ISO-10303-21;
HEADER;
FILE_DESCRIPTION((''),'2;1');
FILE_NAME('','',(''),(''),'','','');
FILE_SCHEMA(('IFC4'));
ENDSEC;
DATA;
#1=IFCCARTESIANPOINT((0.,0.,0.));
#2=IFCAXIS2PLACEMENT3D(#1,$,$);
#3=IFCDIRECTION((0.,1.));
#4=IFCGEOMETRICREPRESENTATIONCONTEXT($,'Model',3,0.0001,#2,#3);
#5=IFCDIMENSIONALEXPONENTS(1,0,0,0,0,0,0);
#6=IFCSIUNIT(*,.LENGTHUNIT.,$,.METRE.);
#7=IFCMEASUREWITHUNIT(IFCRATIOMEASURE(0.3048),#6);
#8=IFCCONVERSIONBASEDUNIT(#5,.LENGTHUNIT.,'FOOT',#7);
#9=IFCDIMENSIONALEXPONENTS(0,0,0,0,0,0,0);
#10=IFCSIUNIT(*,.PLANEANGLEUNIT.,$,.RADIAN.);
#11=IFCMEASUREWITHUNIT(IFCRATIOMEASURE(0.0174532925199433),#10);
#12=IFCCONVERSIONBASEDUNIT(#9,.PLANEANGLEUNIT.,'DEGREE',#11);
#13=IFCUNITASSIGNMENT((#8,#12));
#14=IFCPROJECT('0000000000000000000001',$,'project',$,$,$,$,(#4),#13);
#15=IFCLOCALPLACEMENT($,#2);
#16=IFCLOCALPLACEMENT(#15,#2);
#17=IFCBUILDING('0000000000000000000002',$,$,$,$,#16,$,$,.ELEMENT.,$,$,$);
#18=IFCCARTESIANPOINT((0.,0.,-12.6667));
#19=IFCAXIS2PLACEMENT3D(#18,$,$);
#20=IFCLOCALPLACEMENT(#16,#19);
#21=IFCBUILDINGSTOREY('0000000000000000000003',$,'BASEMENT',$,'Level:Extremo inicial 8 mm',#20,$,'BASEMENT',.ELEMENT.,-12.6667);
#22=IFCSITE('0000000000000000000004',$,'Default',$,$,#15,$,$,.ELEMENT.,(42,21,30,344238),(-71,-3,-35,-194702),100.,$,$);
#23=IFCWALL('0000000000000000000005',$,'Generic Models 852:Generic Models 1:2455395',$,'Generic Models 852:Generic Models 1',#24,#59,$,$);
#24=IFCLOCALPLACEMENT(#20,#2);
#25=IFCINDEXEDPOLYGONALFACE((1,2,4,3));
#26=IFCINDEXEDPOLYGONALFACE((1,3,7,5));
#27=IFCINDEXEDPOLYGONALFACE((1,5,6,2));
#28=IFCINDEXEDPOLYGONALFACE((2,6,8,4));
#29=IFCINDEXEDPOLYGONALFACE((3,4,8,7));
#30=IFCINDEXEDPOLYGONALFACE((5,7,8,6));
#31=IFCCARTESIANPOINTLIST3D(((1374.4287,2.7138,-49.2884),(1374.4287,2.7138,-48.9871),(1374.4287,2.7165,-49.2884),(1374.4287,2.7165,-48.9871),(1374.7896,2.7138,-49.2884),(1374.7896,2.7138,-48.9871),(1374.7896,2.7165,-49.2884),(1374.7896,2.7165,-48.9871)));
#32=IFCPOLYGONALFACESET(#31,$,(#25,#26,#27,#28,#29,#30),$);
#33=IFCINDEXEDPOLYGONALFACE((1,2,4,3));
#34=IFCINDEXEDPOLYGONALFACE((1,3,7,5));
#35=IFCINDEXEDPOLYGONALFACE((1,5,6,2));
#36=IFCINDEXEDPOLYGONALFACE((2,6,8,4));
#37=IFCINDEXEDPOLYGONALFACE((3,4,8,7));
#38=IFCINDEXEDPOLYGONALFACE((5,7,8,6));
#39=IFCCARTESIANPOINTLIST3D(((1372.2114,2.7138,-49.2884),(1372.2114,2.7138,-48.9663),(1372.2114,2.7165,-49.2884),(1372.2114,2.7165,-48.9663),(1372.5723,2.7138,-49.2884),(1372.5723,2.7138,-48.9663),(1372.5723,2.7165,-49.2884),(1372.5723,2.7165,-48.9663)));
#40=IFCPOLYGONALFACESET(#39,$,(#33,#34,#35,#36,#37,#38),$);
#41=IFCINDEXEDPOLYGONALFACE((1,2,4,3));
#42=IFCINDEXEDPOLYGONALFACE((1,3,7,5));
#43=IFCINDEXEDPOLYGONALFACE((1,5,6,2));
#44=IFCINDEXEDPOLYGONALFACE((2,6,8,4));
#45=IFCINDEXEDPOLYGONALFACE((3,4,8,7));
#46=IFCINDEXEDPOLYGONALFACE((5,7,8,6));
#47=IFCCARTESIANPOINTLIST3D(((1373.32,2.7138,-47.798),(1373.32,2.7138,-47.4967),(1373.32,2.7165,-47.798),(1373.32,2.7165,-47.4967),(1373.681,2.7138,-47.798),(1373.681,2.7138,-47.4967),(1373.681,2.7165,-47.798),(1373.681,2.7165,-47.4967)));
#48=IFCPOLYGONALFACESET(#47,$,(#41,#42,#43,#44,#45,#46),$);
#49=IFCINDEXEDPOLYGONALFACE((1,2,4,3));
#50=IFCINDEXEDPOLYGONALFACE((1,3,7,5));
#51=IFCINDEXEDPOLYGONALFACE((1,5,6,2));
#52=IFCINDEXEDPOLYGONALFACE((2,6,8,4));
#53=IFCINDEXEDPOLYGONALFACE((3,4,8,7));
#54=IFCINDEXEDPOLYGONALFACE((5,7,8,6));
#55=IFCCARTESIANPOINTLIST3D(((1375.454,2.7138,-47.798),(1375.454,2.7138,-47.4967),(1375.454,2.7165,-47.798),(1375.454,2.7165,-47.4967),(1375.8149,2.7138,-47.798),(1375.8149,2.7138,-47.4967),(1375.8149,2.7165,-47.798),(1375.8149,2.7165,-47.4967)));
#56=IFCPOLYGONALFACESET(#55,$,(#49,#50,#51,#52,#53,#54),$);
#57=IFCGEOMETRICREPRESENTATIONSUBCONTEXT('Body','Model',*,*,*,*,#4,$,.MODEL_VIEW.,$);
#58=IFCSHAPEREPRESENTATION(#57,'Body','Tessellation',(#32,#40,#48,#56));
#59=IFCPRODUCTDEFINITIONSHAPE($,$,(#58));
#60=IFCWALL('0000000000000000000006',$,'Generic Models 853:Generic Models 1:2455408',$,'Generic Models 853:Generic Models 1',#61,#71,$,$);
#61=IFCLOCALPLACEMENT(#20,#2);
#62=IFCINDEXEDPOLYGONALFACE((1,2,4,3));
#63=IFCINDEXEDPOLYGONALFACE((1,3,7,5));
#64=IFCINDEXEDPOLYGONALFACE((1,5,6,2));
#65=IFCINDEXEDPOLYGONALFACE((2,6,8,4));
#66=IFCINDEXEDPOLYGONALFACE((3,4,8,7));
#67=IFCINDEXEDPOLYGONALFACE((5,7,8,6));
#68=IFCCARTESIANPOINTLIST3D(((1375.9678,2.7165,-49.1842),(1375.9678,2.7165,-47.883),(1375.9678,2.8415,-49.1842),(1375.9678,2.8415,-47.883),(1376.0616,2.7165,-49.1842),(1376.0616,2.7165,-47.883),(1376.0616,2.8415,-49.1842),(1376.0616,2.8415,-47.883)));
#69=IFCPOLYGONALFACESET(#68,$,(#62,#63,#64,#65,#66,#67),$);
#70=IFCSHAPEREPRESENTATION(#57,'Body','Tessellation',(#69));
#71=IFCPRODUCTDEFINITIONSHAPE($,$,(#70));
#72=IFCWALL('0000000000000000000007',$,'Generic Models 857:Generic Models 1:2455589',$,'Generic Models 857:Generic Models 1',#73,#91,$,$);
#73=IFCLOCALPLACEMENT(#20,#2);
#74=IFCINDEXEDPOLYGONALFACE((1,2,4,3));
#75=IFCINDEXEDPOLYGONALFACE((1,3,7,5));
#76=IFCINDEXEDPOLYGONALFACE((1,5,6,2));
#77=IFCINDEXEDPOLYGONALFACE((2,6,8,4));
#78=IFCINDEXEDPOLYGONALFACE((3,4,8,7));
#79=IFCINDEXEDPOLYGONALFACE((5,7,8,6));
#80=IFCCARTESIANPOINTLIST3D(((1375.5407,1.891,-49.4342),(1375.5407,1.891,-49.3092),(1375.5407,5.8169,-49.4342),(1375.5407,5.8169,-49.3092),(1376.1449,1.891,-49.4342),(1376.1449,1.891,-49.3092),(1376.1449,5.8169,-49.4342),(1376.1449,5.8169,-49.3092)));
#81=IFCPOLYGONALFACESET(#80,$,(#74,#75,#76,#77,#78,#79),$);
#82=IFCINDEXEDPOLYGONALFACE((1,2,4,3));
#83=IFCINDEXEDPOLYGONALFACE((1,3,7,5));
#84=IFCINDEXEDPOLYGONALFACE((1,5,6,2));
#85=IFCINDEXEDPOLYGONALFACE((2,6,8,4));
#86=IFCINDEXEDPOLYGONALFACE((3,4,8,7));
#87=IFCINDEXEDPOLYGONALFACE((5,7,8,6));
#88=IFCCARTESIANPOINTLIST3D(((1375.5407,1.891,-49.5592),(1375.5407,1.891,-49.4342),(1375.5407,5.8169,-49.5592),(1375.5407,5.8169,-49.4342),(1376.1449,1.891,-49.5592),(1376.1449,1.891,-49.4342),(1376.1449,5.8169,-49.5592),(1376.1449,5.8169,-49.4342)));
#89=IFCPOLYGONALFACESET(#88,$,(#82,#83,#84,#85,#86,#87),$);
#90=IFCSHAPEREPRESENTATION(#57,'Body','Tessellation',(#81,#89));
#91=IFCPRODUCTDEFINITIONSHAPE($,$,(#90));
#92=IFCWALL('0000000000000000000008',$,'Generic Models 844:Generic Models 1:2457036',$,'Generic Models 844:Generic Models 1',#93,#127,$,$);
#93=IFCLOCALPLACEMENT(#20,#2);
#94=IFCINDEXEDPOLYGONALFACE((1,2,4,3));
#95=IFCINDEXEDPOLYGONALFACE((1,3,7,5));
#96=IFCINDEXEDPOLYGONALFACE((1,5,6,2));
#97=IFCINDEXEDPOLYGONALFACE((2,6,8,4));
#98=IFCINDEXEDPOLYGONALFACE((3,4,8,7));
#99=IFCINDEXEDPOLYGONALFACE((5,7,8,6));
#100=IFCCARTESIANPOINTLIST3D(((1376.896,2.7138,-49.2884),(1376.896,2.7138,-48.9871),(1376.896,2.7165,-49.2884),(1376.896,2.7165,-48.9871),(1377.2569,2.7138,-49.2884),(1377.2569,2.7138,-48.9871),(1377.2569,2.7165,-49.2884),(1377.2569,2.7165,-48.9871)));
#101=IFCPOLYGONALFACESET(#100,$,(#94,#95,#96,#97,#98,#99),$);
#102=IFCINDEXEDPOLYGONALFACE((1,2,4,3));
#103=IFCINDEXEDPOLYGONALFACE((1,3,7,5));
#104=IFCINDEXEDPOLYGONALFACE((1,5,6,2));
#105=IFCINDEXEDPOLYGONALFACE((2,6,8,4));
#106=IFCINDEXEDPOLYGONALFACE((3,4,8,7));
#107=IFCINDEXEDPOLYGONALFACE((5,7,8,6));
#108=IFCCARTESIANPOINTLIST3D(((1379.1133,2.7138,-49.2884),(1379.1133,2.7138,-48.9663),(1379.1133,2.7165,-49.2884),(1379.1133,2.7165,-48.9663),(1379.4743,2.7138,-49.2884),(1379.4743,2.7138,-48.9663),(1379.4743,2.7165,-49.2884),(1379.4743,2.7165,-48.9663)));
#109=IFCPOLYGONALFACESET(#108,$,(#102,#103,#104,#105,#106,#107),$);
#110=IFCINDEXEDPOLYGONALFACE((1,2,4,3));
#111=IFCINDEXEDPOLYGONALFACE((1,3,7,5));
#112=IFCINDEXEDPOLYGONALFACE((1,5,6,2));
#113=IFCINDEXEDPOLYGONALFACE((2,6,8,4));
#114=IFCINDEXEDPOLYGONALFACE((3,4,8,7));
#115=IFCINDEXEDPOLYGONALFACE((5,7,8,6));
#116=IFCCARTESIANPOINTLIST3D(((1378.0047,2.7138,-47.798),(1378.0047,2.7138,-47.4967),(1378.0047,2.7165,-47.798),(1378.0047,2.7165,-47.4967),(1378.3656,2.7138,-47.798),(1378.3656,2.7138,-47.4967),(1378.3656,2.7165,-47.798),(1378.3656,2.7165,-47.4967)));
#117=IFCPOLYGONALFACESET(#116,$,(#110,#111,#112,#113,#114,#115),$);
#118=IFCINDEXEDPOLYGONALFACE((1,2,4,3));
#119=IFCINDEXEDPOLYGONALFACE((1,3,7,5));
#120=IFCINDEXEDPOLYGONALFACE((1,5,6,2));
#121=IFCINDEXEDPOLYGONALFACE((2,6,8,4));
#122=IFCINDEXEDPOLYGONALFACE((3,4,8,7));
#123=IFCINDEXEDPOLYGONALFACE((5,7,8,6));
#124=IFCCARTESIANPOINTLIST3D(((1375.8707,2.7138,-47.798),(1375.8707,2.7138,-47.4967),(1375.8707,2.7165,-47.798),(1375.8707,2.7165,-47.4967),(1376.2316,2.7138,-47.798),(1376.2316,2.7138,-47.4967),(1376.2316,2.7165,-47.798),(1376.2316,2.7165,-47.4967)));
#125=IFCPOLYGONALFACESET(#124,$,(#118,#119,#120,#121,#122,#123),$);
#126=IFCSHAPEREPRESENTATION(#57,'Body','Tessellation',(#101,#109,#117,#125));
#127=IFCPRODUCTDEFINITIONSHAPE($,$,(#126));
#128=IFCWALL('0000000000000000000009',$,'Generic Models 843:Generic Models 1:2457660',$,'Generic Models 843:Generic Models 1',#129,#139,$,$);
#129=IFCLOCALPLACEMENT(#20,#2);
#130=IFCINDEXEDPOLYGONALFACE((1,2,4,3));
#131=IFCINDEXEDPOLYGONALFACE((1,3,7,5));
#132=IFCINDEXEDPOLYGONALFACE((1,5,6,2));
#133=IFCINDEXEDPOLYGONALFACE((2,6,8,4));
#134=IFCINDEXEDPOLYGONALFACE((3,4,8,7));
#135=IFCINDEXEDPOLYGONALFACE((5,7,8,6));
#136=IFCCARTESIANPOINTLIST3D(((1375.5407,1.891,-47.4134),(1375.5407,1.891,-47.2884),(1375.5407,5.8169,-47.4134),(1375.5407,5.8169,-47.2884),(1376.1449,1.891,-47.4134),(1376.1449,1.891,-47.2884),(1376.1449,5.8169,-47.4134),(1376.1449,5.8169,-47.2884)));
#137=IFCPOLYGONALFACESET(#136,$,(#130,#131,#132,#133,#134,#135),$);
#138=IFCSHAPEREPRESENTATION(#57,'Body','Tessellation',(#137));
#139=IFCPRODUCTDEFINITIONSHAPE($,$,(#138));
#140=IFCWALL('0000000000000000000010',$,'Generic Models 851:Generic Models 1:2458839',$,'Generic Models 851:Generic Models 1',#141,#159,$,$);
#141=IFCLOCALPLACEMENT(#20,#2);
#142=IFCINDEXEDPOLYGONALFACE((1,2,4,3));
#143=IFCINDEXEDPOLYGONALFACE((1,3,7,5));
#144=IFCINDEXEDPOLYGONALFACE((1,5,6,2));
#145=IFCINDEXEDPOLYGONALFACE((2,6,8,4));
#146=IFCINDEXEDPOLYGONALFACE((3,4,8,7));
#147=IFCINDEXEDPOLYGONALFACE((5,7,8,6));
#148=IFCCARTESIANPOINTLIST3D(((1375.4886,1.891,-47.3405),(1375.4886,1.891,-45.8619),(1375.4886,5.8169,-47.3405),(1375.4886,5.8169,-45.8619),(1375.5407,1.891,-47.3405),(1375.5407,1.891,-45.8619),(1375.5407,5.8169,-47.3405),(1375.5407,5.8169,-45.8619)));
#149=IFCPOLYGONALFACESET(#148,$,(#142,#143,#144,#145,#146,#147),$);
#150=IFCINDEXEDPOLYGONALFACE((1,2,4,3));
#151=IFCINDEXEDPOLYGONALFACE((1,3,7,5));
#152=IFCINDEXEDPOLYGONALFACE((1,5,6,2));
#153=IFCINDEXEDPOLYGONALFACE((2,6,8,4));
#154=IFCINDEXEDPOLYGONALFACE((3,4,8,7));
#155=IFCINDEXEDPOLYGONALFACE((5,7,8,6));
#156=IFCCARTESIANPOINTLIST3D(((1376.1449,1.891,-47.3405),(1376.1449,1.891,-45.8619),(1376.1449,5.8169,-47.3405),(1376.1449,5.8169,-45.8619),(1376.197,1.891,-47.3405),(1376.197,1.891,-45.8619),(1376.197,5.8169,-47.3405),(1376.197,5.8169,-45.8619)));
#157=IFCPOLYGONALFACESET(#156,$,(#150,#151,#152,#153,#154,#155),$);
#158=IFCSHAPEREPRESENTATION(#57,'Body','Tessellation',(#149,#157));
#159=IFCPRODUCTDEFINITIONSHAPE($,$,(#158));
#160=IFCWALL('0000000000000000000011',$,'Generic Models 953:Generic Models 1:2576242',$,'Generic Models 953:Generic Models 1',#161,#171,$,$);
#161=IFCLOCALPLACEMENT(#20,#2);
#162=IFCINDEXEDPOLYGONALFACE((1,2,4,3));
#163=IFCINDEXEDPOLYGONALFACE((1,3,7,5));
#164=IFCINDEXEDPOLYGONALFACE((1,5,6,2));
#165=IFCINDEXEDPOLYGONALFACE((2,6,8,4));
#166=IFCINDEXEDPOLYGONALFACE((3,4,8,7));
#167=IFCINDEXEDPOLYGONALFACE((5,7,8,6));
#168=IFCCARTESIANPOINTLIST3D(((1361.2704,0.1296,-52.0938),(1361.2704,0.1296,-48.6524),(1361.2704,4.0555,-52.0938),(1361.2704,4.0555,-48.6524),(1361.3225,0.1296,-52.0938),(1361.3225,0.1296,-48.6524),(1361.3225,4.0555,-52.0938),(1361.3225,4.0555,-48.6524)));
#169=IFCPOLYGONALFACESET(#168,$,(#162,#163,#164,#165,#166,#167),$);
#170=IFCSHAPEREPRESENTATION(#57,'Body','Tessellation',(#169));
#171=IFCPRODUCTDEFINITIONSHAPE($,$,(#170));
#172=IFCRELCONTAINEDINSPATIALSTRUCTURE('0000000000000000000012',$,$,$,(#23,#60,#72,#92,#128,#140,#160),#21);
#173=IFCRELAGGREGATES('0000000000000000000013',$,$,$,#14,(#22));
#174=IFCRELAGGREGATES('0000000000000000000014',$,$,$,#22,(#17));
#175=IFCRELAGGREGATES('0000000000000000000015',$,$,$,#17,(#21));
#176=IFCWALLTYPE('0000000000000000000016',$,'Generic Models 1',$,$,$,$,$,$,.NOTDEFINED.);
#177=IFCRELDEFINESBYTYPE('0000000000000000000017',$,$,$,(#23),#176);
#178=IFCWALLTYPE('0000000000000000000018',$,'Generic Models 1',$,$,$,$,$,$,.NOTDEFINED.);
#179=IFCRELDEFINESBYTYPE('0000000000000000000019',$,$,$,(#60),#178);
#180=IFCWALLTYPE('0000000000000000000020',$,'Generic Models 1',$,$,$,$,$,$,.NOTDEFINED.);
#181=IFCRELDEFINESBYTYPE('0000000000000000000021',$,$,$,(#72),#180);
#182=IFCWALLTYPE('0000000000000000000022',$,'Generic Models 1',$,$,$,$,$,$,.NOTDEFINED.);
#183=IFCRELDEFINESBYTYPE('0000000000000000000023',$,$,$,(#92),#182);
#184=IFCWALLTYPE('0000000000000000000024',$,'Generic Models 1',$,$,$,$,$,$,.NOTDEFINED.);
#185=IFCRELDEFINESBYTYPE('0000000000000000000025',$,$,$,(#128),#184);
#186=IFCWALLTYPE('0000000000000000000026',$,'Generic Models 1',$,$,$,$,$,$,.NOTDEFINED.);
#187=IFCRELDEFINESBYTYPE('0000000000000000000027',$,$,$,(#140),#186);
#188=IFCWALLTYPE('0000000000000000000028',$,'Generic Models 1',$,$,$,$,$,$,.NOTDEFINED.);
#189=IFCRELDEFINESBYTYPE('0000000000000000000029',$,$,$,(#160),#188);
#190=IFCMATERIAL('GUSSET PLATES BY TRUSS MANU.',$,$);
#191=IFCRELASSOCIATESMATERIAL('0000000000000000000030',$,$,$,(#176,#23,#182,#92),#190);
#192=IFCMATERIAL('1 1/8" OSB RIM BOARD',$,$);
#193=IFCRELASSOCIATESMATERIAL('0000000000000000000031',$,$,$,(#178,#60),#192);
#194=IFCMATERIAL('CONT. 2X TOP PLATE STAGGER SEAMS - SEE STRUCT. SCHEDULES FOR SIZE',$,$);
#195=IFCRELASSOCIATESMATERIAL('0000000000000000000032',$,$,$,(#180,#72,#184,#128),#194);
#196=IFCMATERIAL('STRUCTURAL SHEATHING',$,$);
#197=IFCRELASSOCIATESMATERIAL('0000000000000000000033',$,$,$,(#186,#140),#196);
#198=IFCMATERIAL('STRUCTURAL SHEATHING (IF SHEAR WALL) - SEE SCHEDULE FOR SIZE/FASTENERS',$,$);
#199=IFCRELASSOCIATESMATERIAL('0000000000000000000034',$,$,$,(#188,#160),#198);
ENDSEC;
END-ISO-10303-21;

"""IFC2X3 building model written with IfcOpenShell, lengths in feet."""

from ifc_helpers import new_model, entity, si_unit, converted_unit, direction, frame, frame_2d, origin, origin_2d_with_axis, place, context, subcontext, project, spatial, rectangle, extrude, material, type_object, element, save


model = new_model("IFC2X3")

# Units and contexts
model_context = context("Model", 3, precision=0.0001, world=origin(), true_north=direction((0.0, 1.0)))
body_context = subcontext(model_context, "Body", "Model", "MODEL_VIEW")
ifc_project = project(units=[converted_unit("LENGTHUNIT", "FOOT", entity("IfcRatioMeasure", 0.3048), si_unit("LENGTHUNIT", "METRE"), dimensions=[1, 0, 0, 0, 0, 0, 0]), converted_unit("PLANEANGLEUNIT", "DEGREE", entity("IfcRatioMeasure", 0.0174532925199433), si_unit("PLANEANGLEUNIT", "RADIAN"), dimensions=[0, 0, 0, 0, 0, 0, 0])], contexts=[model_context])

# Site, building, storey
site_placement = place(None, origin())
site = spatial("IfcSite", under=ifc_project, at=site_placement, Name="Default", CompositionType="ELEMENT", RefLatitude=(42, 21, 30, 344238), RefLongitude=(-71, -3, -35, -194702), RefElevation=100.0)
building_placement = place(site_placement, origin())
building = spatial("IfcBuilding", under=site, at=building_placement, CompositionType="ELEMENT")
storey_placement = place(building_placement, frame((0.0, 0.0, -12.6667)))
storey = spatial("IfcBuildingStorey", under=building, at=storey_placement, Name="BASEMENT", ObjectType="Level:Extremo inicial 8 mm", LongName="BASEMENT", CompositionType="ELEMENT", Elevation=-12.6667)

# Walls
ifc_material_1 = material(Name="STRUCTURAL SHEATHING")
ifc_material_2 = material(Name="GUSSET PLATES BY TRUSS MANU.")
wall_type_1 = type_object("IfcWallType", Name="Generic Models 1", PredefinedType="NOTDEFINED", material=ifc_material_2)
wall_1_placement = place(storey_placement, frame((1372.2114, 2.7138, -49.2884)))
element("IfcWall", 1, at=wall_1_placement, inside=storey, type_object=wall_type_1, material=ifc_material_2, Name="Generic Models 852:Generic Models 1:2455395", ObjectType="Generic Models 852:Generic Models 1", context=body_context, shape_type="SweptSolid", body=[
    extrude(rectangle(XDim=0.0028, YDim=0.3609, at=frame_2d((0.0, 0.0), x_axis=(1.0, 0.0))), frame((2.3978, 0.0014, 0.0), z_axis=(0.0, 0.0, 1.0), x_axis=(0.0, 1.0, 0.0)), (0.0, 0.0, 1.0), 0.3013),
    extrude(rectangle(XDim=0.0028, YDim=0.3609, at=frame_2d((0.0, 0.0), x_axis=(1.0, 0.0))), frame((0.1805, 0.0014, 0.0), z_axis=(0.0, 0.0, 1.0), x_axis=(0.0, 1.0, 0.0)), (0.0, 0.0, 1.0), 0.3221),
    extrude(rectangle(XDim=0.0028, YDim=0.3609, at=frame_2d((0.0, 0.0), x_axis=(1.0, 0.0))), frame((1.2891, 0.0014, 1.4904), z_axis=(0.0, 0.0, 1.0), x_axis=(0.0, 1.0, 0.0)), (0.0, 0.0, 1.0), 0.3013),
    extrude(rectangle(XDim=0.0028, YDim=0.3609, at=frame_2d((0.0, 0.0), x_axis=(1.0, 0.0))), frame((3.4231, 0.0014, 1.4904), z_axis=(0.0, 0.0, 1.0), x_axis=(0.0, 1.0, 0.0)), (0.0, 0.0, 1.0), 0.3013),
])
ifc_material_3 = material(Name="1 1/8\" OSB RIM BOARD")
wall_type_2 = type_object("IfcWallType", Name="Generic Models 1", PredefinedType="NOTDEFINED", material=ifc_material_3)
wall_2_placement = place(storey_placement, frame((1375.9678, 2.7165, -49.1842), z_axis=(0.0, 0.0, 1.0), x_axis=(0.0, 1.0, 0.0)))
element("IfcWall", 2, at=wall_2_placement, inside=storey, type_object=wall_type_2, material=ifc_material_3, Name="Generic Models 853:Generic Models 1:2455408", ObjectType="Generic Models 853:Generic Models 1", context=body_context, shape_type="SweptSolid", body=[
    extrude(rectangle(XDim=0.125, YDim=0.0938, at=frame_2d((0.0, 0.0), x_axis=(1.0, 0.0))), frame((0.0625, -0.0469, 0.0)), (0.0, 0.0, 1.0), 1.3012),
])
ifc_material_4 = material(Name="CONT. 2X TOP PLATE STAGGER SEAMS - SEE STRUCT. SCHEDULES FOR SIZE")
wall_type_3 = type_object("IfcWallType", Name="Generic Models 1", PredefinedType="NOTDEFINED", material=ifc_material_4)
wall_3_placement = place(storey_placement, frame((1375.5407, 1.891, -49.5592), z_axis=(0.0, 0.0, 1.0), x_axis=(0.0, 1.0, 0.0)))
element("IfcWall", 3, at=wall_3_placement, inside=storey, type_object=wall_type_3, material=ifc_material_4, Name="Generic Models 857:Generic Models 1:2455589", ObjectType="Generic Models 857:Generic Models 1", context=body_context, shape_type="SweptSolid", body=[
    extrude(rectangle(XDim=3.9258, YDim=0.6042, at=frame_2d((0.0, 0.0), x_axis=(1.0, 0.0))), frame((1.9629, -0.3021, 0.125)), (0.0, 0.0, 1.0), 0.125),
    extrude(rectangle(XDim=3.9258, YDim=0.6042, at=frame_2d((0.0, 0.0), x_axis=(1.0, 0.0))), frame((1.9629, -0.3021, 0.0)), (0.0, 0.0, 1.0), 0.125),
])
wall_type_4 = type_object("IfcWallType", Name="Generic Models 1", PredefinedType="NOTDEFINED", material=ifc_material_2)
wall_4_placement = place(storey_placement, frame((1375.8707, 2.7138, -49.2884)))
element("IfcWall", 4, at=wall_4_placement, inside=storey, type_object=wall_type_4, material=ifc_material_2, Name="Generic Models 844:Generic Models 1:2457036", ObjectType="Generic Models 844:Generic Models 1", context=body_context, shape_type="SweptSolid", body=[
    extrude(rectangle(XDim=0.0028, YDim=0.3609, at=origin_2d_with_axis()), frame((1.2058, 0.0014, 0.0), z_axis=(0.0, 0.0, 1.0), x_axis=(0.0, 1.0, 0.0)), (0.0, 0.0, 1.0), 0.3013),
    extrude(rectangle(XDim=0.0028, YDim=0.3609, at=origin_2d_with_axis()), frame((3.4231, 0.0014, 0.0), z_axis=(0.0, 0.0, 1.0), x_axis=(0.0, 1.0, 0.0)), (0.0, 0.0, 1.0), 0.3221),
    extrude(rectangle(XDim=0.0028, YDim=0.3609, at=origin_2d_with_axis()), frame((2.3145, 0.0014, 1.4904), z_axis=(0.0, 0.0, 1.0), x_axis=(0.0, 1.0, 0.0)), (0.0, 0.0, 1.0), 0.3013),
    extrude(rectangle(XDim=0.0028, YDim=0.3609, at=origin_2d_with_axis()), frame((0.1805, 0.0014, 1.4904), z_axis=(0.0, 0.0, 1.0), x_axis=(0.0, 1.0, 0.0)), (0.0, 0.0, 1.0), 0.3013),
])
wall_type_5 = type_object("IfcWallType", Name="Generic Models 1", PredefinedType="NOTDEFINED", material=ifc_material_4)
wall_5_placement = place(storey_placement, frame((1375.5407, 1.891, -47.4134), z_axis=(0.0, 0.0, 1.0), x_axis=(0.0, 1.0, 0.0)))
element("IfcWall", 5, at=wall_5_placement, inside=storey, type_object=wall_type_5, material=ifc_material_4, Name="Generic Models 843:Generic Models 1:2457660", ObjectType="Generic Models 843:Generic Models 1", context=body_context, shape_type="SweptSolid", body=[
    extrude(rectangle(XDim=3.9258, YDim=0.6042, at=frame_2d((0.0, 0.0), x_axis=(1.0, 0.0))), frame((1.9629, -0.3021, 0.0)), (0.0, 0.0, 1.0), 0.125),
])
wall_type_6 = type_object("IfcWallType", Name="Generic Models 1", PredefinedType="NOTDEFINED", material=ifc_material_1)
wall_6_placement = place(storey_placement, frame((1375.4886, 1.891, -47.3405), z_axis=(0.0, 0.0, 1.0), x_axis=(0.0, 1.0, 0.0)))
element("IfcWall", 6, at=wall_6_placement, inside=storey, type_object=wall_type_6, material=ifc_material_1, Name="Generic Models 851:Generic Models 1:2458839", ObjectType="Generic Models 851:Generic Models 1", context=body_context, shape_type="SweptSolid", body=[
    extrude(rectangle(XDim=3.9258, YDim=0.0521, at=frame_2d((0.0, 0.0), x_axis=(1.0, 0.0))), frame((1.9629, -0.026, 0.0)), (0.0, 0.0, 1.0), 1.4786),
    extrude(rectangle(XDim=3.9258, YDim=0.0521, at=frame_2d((0.0, 0.0), x_axis=(1.0, 0.0))), frame((1.9629, -0.6823, 0.0)), (0.0, 0.0, 1.0), 1.4786),
])
ifc_material_5 = material(Name="STRUCTURAL SHEATHING (IF SHEAR WALL) - SEE SCHEDULE FOR SIZE/FASTENERS")
wall_type_7 = type_object("IfcWallType", Name="Generic Models 1", PredefinedType="NOTDEFINED", material=ifc_material_5)
wall_7_placement = place(storey_placement, frame((1361.2704, 0.1296, -52.0938), z_axis=(0.0, 0.0, 1.0), x_axis=(0.0, 1.0, 0.0)))
element("IfcWall", 7, at=wall_7_placement, inside=storey, type_object=wall_type_7, material=ifc_material_5, Name="Generic Models 953:Generic Models 1:2576242", ObjectType="Generic Models 953:Generic Models 1", context=body_context, shape_type="SweptSolid", body=[
    extrude(rectangle(XDim=3.9258, YDim=0.0521, at=frame_2d((0.0, 0.0), x_axis=(1.0, 0.0))), frame((1.9629, -0.026, 0.0)), (0.0, 0.0, 1.0), 3.4413),
])

save(model, "model.ifc")
